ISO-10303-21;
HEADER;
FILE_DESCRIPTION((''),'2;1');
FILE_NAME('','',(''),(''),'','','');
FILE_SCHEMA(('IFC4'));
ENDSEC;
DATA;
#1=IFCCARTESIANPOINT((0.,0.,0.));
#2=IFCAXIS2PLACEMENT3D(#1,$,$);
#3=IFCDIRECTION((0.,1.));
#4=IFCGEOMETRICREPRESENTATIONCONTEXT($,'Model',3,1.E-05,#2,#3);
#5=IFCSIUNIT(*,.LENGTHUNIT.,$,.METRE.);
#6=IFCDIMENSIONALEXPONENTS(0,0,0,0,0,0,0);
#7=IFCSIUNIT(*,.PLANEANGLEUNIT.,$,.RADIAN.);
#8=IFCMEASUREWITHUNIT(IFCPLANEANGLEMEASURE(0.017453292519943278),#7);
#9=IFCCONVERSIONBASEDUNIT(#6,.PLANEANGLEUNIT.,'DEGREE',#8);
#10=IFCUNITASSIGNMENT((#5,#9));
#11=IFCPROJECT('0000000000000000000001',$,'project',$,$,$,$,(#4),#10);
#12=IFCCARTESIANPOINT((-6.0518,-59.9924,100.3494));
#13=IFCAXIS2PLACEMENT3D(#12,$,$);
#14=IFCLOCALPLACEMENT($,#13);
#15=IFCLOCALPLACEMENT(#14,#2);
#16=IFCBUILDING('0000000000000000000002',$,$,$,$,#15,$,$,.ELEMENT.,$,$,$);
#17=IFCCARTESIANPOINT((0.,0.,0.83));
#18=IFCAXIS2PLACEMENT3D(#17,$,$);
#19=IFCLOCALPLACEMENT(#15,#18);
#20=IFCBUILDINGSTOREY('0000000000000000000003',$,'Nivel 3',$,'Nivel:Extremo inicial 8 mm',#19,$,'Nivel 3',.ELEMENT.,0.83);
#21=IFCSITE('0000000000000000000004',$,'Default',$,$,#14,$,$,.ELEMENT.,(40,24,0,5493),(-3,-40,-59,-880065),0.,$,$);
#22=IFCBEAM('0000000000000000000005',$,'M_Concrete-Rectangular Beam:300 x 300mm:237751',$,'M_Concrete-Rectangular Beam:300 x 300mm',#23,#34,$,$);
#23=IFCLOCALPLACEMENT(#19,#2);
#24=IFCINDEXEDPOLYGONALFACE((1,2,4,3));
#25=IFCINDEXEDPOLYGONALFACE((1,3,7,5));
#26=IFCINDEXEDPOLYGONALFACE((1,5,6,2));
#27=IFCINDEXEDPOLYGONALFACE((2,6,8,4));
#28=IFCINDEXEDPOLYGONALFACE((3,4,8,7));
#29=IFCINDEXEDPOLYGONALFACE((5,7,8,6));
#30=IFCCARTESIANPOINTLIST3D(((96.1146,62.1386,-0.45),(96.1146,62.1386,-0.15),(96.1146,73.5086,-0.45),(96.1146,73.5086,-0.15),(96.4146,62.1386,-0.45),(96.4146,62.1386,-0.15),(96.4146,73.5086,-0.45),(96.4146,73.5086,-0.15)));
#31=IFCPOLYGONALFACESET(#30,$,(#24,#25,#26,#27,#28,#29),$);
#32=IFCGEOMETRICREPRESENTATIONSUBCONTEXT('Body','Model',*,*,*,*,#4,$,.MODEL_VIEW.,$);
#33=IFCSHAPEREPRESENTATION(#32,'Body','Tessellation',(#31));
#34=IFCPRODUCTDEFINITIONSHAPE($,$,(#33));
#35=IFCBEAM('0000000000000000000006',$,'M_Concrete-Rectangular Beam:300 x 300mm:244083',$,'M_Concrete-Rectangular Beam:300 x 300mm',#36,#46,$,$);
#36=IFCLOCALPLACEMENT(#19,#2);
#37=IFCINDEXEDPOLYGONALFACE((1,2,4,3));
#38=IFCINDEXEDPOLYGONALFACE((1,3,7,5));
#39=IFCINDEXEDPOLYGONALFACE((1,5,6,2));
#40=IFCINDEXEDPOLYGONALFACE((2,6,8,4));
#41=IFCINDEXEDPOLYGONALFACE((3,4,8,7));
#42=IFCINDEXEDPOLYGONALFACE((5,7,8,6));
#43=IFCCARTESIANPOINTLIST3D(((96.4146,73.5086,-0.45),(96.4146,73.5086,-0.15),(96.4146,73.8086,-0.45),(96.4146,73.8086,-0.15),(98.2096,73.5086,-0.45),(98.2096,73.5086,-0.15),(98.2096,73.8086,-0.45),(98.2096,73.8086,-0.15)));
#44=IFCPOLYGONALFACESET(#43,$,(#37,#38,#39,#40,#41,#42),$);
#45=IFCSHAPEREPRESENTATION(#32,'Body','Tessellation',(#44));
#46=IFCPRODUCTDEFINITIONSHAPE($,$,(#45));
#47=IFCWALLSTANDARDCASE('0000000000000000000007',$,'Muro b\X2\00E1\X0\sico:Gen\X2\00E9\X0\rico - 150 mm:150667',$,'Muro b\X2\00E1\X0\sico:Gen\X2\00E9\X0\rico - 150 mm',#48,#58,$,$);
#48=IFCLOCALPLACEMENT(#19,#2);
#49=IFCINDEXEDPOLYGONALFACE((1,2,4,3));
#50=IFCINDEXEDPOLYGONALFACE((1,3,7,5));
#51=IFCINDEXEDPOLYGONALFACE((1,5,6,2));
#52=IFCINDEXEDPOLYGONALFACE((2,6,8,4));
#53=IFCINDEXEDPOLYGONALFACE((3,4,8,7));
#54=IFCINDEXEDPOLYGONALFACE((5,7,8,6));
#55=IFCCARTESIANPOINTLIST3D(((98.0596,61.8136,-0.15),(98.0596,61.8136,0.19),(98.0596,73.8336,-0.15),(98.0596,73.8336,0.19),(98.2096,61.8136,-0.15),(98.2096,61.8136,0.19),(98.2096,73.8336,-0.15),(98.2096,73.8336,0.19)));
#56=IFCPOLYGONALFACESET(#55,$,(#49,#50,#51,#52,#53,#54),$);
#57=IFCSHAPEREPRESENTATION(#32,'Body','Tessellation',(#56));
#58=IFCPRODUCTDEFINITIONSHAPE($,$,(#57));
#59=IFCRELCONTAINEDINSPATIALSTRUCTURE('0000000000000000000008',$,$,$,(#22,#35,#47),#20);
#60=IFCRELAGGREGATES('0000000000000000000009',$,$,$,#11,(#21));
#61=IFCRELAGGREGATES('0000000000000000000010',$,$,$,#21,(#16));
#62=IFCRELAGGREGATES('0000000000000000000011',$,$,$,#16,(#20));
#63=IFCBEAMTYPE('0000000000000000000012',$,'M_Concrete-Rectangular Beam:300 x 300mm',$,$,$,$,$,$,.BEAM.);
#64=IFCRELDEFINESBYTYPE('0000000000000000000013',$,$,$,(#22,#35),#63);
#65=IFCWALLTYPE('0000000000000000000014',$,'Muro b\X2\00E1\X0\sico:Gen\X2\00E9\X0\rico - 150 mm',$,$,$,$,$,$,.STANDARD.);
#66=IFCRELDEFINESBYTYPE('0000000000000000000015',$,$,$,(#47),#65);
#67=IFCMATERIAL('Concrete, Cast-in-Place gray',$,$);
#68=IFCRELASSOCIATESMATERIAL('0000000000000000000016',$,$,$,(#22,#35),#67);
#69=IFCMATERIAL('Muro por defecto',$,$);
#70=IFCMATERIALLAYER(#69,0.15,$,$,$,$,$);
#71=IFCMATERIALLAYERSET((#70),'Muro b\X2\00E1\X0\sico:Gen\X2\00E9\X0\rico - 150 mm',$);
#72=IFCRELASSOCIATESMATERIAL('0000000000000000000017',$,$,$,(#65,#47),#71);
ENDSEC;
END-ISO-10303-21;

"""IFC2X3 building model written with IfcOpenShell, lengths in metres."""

from ifc_helpers import new_model, entity, si_unit, converted_unit, direction, frame, frame_2d, origin, place, context, subcontext, project, spatial, polyline, rectangle, extrude, clip, bounded_halfspace, material, layer, layer_set, layer_usage, type_object, element, save


model = new_model("IFC2X3")

# Units and contexts
model_context = context("Model", 3, precision=1e-05, world=origin(), true_north=direction((0.0, 1.0)))
body_context = subcontext(model_context, "Body", "Model", "MODEL_VIEW")
ifc_project = project(units=[si_unit("LENGTHUNIT", "METRE"), converted_unit("PLANEANGLEUNIT", "DEGREE", entity("IfcPlaneAngleMeasure", 0.017453292519943278), si_unit("PLANEANGLEUNIT", "RADIAN"), dimensions=[0, 0, 0, 0, 0, 0, 0])], contexts=[model_context])

# Site, building, storey
site_placement = place(None, frame((-6.0518, -59.9924, 100.3494)))
site = spatial("IfcSite", under=ifc_project, at=site_placement, Name="Default", CompositionType="ELEMENT", RefLatitude=(40, 24, 0, 5493), RefLongitude=(-3, -40, -59, -880065), RefElevation=0.0)
building_placement = place(site_placement, origin())
building = spatial("IfcBuilding", under=site, at=building_placement, CompositionType="ELEMENT")
storey_placement = place(building_placement, frame((0.0, 0.0, 0.83)))
storey = spatial("IfcBuildingStorey", under=building, at=storey_placement, Name="Nivel 3", ObjectType="Nivel:Extremo inicial 8 mm", LongName="Nivel 3", CompositionType="ELEMENT", Elevation=0.83)

# Beams
ifc_material_1 = material(Name="Concrete, Cast-in-Place gray")
beam_type = type_object("IfcBeamType", Name="M_Concrete-Rectangular Beam:300 x 300mm", PredefinedType="BEAM")
beam_1_placement = place(storey_placement, frame((96.2646, 73.6586, 0.0), z_axis=(0.0, 0.0, 1.0), x_axis=(0.0, -1.0, 0.0)))
element("IfcBeam", 1, at=beam_1_placement, inside=storey, type_object=beam_type, material=ifc_material_1, Name="M_Concrete-Rectangular Beam:300 x 300mm:237751", ObjectType="M_Concrete-Rectangular Beam:300 x 300mm", context=body_context, shape_type="SweptSolid", body=[
    extrude(rectangle(XDim=0.3, YDim=0.3, at=frame_2d((0.0, 0.0), x_axis=(1.0, 0.0))), frame((0.15, 0.0, -0.3), z_axis=(1.0, 0.0, 0.0), x_axis=(0.0, 0.0, -1.0)), (0.0, 0.0, 1.0), 11.37),
])
beam_2_placement = place(storey_placement, frame((96.2646, 73.6586, 0.0)))
element("IfcBeam", 2, at=beam_2_placement, inside=storey, type_object=beam_type, material=ifc_material_1, Name="M_Concrete-Rectangular Beam:300 x 300mm:244083", ObjectType="M_Concrete-Rectangular Beam:300 x 300mm", context=body_context, shape_type="SweptSolid", body=[
    extrude(rectangle(XDim=0.3, YDim=0.3, at=frame_2d((0.0, 0.0), x_axis=(1.0, 0.0))), frame((0.15, 0.0, -0.3), z_axis=(1.0, 0.0, 0.0), x_axis=(0.0, 0.0, -1.0)), (0.0, 0.0, 1.0), 1.795),
])

# Wall
ifc_material_2 = material(Name="Muro por defecto")
ifc_layer = layer(ifc_material_2, 0.15)
ifc_layer_set = layer_set([ifc_layer], Name="Muro básico:Genérico - 150 mm")
ifc_layer_usage = layer_usage(ifc_layer_set, "AXIS2", "NEGATIVE", 0.075)
wall_type = type_object("IfcWallType", Name="Muro básico:Genérico - 150 mm", PredefinedType="STANDARD", material=ifc_layer_set)
wall_placement = place(storey_placement, frame((98.1346, 73.8336, -0.15), z_axis=(0.0, 0.0, 1.0), x_axis=(0.0, -1.0, 0.0)))
element("IfcWallStandardCase", 3, at=wall_placement, inside=storey, type_object=wall_type, material=ifc_layer_usage, Name="Muro básico:Genérico - 150 mm:150667", ObjectType="Muro básico:Genérico - 150 mm", context=body_context, shape_type="Clipping", body=[
    clip(extrude(rectangle(XDim=12.02, YDim=0.15, at=frame_2d((6.01, 0.0), x_axis=(-1.0, 0.0))), origin(), (0.0, 0.0, 1.0), 0.34), bounded_halfspace(frame((0.0, -0.075, 0.34), z_axis=(0.0, 0.0, -1.0), x_axis=(1.0, 0.0, 0.0)), True, frame((0.0, -0.075, 0.34), z_axis=(0.0, 0.0, -1.0), x_axis=(1.0, 0.0, 0.0)), polyline([(0.0, 0.0), (0.0, -0.15), (12.02, -0.15), (12.02, 0.0), (0.0, 0.0)]))),
])

save(model, "model.ifc")
